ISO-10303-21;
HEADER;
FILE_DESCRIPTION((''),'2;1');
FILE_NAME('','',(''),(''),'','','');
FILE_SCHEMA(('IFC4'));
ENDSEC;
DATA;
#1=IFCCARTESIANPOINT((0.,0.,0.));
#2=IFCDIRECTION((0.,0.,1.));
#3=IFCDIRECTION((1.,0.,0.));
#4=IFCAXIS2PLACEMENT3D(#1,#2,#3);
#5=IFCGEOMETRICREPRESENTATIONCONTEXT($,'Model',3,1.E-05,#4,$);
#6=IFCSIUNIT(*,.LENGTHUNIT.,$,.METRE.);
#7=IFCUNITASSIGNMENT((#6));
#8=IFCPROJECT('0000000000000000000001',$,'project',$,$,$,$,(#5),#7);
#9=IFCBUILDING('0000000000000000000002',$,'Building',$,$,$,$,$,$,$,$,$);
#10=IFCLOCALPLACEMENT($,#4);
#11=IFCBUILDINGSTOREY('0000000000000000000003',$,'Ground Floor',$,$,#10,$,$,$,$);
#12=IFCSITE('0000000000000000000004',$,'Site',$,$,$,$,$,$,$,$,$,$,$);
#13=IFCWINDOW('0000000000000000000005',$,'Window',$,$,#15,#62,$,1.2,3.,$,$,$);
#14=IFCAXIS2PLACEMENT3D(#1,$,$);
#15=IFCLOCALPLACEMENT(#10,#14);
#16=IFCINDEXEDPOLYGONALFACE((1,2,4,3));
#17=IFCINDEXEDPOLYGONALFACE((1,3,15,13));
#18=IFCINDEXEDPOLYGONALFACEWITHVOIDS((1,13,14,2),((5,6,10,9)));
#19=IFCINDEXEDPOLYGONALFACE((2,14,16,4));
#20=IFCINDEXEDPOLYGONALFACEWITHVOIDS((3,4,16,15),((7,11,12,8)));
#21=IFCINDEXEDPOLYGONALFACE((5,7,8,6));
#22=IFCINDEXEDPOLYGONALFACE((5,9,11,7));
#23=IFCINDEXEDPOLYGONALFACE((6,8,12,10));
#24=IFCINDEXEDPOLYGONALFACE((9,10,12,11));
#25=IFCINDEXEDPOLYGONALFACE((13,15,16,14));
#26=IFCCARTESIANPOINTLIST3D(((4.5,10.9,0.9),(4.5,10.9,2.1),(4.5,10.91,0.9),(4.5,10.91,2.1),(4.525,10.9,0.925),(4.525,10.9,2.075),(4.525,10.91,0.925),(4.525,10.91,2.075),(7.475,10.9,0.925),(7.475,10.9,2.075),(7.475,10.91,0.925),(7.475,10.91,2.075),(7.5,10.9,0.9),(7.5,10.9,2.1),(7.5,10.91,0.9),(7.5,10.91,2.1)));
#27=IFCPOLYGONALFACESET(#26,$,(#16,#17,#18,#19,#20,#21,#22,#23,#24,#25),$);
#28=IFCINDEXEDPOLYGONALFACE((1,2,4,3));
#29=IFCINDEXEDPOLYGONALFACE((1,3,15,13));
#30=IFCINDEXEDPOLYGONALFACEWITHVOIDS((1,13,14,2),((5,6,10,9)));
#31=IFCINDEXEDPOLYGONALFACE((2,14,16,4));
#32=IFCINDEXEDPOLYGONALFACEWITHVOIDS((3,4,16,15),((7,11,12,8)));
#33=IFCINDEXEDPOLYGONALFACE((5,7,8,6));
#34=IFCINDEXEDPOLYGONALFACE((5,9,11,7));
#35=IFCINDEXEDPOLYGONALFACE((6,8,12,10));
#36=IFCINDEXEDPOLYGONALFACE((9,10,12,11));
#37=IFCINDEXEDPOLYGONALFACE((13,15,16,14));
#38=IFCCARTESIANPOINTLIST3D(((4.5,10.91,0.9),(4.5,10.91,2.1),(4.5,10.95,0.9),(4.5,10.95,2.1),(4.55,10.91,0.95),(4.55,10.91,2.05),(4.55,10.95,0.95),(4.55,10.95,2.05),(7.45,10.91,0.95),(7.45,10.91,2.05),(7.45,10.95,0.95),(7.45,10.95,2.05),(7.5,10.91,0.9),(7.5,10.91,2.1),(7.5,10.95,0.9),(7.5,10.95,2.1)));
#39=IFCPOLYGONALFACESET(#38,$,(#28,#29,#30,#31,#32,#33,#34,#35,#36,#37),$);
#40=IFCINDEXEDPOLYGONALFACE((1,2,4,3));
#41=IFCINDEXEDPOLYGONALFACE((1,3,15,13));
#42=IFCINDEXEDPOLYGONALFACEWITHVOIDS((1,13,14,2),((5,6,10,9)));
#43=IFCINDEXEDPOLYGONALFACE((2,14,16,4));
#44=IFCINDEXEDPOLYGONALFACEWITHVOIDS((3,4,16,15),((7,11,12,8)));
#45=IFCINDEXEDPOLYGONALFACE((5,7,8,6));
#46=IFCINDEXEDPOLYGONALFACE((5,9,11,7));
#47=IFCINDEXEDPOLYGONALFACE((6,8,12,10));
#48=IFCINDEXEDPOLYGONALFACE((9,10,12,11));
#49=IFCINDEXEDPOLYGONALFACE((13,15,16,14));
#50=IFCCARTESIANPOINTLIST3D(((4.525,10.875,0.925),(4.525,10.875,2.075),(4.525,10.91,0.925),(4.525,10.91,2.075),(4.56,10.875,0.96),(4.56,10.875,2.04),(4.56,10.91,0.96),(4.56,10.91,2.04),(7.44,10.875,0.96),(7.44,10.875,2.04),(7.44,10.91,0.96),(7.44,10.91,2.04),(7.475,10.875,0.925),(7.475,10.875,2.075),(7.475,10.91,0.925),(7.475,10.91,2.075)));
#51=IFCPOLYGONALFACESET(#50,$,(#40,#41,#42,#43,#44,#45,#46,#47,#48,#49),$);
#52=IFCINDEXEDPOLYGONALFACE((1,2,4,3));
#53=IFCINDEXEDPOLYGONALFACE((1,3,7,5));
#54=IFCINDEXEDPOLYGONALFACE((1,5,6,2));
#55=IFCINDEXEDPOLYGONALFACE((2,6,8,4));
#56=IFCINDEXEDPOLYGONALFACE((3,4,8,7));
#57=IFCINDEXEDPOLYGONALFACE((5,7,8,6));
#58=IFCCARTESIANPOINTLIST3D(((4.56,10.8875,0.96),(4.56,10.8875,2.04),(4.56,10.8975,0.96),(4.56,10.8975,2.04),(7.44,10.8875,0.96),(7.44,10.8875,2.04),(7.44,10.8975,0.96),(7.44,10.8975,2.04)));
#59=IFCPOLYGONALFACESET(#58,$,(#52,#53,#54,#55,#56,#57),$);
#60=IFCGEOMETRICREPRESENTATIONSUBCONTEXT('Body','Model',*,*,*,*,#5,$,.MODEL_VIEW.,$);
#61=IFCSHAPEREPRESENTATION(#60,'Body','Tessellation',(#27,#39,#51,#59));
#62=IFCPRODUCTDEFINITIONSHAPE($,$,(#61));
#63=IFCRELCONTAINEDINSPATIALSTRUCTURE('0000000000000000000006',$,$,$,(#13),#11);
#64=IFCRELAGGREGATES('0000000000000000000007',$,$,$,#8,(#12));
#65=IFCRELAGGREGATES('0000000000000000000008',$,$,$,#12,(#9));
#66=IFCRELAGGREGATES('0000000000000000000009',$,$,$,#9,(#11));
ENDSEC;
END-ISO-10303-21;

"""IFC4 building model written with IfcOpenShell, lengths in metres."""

from ifc_helpers import new_model, si_unit, frame, origin_with_axes, place, context, subcontext, project, spatial, line, indexed_curve, outline, extrude, element, save


model = new_model("IFC4")

# Units and contexts
model_context = context("Model", 3, precision=1e-05, world=origin_with_axes())
body_context = subcontext(model_context, "Body", "Model", "MODEL_VIEW")
ifc_project = project(units=[si_unit("LENGTHUNIT", "METRE")], contexts=[model_context])

# Site, building, storey
site = spatial("IfcSite", under=ifc_project, Name="Site")
building = spatial("IfcBuilding", under=site, Name="Building")
storey_placement = place(None, origin_with_axes())
storey = spatial("IfcBuildingStorey", under=building, at=storey_placement, Name="Ground Floor")

# Window
window_1_placement = place(storey_placement, frame((7.5, 11.0, 0.9), z_axis=(0.0, 0.0, 1.0), x_axis=(-1.0, 0.0, 0.0)))
element("IfcWindow", 1, at=window_1_placement, inside=storey, Name="Window", OverallHeight=1.2, OverallWidth=3.0, context=body_context, shape_type="SweptSolid", body=[
    extrude(outline(indexed_curve([(0.0, 0.0), (3.0, 0.0), (3.0, 1.2), (0.0, 1.2)], segments=[line(1, 2, 3, 4, 1)]), holes=[indexed_curve([(0.025, 0.025), (2.975, 0.025), (2.975, 1.175), (0.025, 1.175)], segments=[line(1, 2, 3, 4, 1)])]), frame((0.0, 0.09, 0.0), z_axis=(0.0, -1.0, 0.0), x_axis=(1.0, 0.0, 0.0)), (0.0, 0.0, -1.0), 0.01),
    extrude(outline(indexed_curve([(0.0, 0.0), (3.0, 0.0), (3.0, 1.2), (0.0, 1.2)], segments=[line(1, 2, 3, 4, 1)]), holes=[indexed_curve([(0.05, 0.05), (2.95, 0.05), (2.95, 1.15), (0.05, 1.15)], segments=[line(1, 2, 3, 4, 1)])]), frame((0.0, 0.05, 0.0), z_axis=(0.0, -1.0, 0.0), x_axis=(1.0, 0.0, 0.0)), (0.0, 0.0, -1.0), 0.04),
    extrude(outline(indexed_curve([(0.0, 0.0), (2.95, 0.0), (2.95, 1.15), (0.0, 1.15)], segments=[line(1, 2, 3, 4, 1)]), holes=[indexed_curve([(0.035, 0.035), (2.915, 0.035), (2.915, 1.115), (0.035, 1.115)], segments=[line(1, 2, 3, 4, 1)])]), frame((0.025, 0.09, 0.025), z_axis=(0.0, -1.0, 0.0), x_axis=(1.0, 0.0, 0.0)), (0.0, 0.0, -1.0), 0.035),
    extrude(outline(indexed_curve([(0.035, 0.035), (2.915, 0.035), (2.915, 1.115), (0.035, 1.115)], segments=[line(1, 2, 3, 4, 1)])), frame((0.025, 0.1025, 0.025), z_axis=(0.0, -1.0, 0.0), x_axis=(1.0, 0.0, 0.0)), (0.0, 0.0, -1.0), 0.01),
])

save(model, "model.ifc")
